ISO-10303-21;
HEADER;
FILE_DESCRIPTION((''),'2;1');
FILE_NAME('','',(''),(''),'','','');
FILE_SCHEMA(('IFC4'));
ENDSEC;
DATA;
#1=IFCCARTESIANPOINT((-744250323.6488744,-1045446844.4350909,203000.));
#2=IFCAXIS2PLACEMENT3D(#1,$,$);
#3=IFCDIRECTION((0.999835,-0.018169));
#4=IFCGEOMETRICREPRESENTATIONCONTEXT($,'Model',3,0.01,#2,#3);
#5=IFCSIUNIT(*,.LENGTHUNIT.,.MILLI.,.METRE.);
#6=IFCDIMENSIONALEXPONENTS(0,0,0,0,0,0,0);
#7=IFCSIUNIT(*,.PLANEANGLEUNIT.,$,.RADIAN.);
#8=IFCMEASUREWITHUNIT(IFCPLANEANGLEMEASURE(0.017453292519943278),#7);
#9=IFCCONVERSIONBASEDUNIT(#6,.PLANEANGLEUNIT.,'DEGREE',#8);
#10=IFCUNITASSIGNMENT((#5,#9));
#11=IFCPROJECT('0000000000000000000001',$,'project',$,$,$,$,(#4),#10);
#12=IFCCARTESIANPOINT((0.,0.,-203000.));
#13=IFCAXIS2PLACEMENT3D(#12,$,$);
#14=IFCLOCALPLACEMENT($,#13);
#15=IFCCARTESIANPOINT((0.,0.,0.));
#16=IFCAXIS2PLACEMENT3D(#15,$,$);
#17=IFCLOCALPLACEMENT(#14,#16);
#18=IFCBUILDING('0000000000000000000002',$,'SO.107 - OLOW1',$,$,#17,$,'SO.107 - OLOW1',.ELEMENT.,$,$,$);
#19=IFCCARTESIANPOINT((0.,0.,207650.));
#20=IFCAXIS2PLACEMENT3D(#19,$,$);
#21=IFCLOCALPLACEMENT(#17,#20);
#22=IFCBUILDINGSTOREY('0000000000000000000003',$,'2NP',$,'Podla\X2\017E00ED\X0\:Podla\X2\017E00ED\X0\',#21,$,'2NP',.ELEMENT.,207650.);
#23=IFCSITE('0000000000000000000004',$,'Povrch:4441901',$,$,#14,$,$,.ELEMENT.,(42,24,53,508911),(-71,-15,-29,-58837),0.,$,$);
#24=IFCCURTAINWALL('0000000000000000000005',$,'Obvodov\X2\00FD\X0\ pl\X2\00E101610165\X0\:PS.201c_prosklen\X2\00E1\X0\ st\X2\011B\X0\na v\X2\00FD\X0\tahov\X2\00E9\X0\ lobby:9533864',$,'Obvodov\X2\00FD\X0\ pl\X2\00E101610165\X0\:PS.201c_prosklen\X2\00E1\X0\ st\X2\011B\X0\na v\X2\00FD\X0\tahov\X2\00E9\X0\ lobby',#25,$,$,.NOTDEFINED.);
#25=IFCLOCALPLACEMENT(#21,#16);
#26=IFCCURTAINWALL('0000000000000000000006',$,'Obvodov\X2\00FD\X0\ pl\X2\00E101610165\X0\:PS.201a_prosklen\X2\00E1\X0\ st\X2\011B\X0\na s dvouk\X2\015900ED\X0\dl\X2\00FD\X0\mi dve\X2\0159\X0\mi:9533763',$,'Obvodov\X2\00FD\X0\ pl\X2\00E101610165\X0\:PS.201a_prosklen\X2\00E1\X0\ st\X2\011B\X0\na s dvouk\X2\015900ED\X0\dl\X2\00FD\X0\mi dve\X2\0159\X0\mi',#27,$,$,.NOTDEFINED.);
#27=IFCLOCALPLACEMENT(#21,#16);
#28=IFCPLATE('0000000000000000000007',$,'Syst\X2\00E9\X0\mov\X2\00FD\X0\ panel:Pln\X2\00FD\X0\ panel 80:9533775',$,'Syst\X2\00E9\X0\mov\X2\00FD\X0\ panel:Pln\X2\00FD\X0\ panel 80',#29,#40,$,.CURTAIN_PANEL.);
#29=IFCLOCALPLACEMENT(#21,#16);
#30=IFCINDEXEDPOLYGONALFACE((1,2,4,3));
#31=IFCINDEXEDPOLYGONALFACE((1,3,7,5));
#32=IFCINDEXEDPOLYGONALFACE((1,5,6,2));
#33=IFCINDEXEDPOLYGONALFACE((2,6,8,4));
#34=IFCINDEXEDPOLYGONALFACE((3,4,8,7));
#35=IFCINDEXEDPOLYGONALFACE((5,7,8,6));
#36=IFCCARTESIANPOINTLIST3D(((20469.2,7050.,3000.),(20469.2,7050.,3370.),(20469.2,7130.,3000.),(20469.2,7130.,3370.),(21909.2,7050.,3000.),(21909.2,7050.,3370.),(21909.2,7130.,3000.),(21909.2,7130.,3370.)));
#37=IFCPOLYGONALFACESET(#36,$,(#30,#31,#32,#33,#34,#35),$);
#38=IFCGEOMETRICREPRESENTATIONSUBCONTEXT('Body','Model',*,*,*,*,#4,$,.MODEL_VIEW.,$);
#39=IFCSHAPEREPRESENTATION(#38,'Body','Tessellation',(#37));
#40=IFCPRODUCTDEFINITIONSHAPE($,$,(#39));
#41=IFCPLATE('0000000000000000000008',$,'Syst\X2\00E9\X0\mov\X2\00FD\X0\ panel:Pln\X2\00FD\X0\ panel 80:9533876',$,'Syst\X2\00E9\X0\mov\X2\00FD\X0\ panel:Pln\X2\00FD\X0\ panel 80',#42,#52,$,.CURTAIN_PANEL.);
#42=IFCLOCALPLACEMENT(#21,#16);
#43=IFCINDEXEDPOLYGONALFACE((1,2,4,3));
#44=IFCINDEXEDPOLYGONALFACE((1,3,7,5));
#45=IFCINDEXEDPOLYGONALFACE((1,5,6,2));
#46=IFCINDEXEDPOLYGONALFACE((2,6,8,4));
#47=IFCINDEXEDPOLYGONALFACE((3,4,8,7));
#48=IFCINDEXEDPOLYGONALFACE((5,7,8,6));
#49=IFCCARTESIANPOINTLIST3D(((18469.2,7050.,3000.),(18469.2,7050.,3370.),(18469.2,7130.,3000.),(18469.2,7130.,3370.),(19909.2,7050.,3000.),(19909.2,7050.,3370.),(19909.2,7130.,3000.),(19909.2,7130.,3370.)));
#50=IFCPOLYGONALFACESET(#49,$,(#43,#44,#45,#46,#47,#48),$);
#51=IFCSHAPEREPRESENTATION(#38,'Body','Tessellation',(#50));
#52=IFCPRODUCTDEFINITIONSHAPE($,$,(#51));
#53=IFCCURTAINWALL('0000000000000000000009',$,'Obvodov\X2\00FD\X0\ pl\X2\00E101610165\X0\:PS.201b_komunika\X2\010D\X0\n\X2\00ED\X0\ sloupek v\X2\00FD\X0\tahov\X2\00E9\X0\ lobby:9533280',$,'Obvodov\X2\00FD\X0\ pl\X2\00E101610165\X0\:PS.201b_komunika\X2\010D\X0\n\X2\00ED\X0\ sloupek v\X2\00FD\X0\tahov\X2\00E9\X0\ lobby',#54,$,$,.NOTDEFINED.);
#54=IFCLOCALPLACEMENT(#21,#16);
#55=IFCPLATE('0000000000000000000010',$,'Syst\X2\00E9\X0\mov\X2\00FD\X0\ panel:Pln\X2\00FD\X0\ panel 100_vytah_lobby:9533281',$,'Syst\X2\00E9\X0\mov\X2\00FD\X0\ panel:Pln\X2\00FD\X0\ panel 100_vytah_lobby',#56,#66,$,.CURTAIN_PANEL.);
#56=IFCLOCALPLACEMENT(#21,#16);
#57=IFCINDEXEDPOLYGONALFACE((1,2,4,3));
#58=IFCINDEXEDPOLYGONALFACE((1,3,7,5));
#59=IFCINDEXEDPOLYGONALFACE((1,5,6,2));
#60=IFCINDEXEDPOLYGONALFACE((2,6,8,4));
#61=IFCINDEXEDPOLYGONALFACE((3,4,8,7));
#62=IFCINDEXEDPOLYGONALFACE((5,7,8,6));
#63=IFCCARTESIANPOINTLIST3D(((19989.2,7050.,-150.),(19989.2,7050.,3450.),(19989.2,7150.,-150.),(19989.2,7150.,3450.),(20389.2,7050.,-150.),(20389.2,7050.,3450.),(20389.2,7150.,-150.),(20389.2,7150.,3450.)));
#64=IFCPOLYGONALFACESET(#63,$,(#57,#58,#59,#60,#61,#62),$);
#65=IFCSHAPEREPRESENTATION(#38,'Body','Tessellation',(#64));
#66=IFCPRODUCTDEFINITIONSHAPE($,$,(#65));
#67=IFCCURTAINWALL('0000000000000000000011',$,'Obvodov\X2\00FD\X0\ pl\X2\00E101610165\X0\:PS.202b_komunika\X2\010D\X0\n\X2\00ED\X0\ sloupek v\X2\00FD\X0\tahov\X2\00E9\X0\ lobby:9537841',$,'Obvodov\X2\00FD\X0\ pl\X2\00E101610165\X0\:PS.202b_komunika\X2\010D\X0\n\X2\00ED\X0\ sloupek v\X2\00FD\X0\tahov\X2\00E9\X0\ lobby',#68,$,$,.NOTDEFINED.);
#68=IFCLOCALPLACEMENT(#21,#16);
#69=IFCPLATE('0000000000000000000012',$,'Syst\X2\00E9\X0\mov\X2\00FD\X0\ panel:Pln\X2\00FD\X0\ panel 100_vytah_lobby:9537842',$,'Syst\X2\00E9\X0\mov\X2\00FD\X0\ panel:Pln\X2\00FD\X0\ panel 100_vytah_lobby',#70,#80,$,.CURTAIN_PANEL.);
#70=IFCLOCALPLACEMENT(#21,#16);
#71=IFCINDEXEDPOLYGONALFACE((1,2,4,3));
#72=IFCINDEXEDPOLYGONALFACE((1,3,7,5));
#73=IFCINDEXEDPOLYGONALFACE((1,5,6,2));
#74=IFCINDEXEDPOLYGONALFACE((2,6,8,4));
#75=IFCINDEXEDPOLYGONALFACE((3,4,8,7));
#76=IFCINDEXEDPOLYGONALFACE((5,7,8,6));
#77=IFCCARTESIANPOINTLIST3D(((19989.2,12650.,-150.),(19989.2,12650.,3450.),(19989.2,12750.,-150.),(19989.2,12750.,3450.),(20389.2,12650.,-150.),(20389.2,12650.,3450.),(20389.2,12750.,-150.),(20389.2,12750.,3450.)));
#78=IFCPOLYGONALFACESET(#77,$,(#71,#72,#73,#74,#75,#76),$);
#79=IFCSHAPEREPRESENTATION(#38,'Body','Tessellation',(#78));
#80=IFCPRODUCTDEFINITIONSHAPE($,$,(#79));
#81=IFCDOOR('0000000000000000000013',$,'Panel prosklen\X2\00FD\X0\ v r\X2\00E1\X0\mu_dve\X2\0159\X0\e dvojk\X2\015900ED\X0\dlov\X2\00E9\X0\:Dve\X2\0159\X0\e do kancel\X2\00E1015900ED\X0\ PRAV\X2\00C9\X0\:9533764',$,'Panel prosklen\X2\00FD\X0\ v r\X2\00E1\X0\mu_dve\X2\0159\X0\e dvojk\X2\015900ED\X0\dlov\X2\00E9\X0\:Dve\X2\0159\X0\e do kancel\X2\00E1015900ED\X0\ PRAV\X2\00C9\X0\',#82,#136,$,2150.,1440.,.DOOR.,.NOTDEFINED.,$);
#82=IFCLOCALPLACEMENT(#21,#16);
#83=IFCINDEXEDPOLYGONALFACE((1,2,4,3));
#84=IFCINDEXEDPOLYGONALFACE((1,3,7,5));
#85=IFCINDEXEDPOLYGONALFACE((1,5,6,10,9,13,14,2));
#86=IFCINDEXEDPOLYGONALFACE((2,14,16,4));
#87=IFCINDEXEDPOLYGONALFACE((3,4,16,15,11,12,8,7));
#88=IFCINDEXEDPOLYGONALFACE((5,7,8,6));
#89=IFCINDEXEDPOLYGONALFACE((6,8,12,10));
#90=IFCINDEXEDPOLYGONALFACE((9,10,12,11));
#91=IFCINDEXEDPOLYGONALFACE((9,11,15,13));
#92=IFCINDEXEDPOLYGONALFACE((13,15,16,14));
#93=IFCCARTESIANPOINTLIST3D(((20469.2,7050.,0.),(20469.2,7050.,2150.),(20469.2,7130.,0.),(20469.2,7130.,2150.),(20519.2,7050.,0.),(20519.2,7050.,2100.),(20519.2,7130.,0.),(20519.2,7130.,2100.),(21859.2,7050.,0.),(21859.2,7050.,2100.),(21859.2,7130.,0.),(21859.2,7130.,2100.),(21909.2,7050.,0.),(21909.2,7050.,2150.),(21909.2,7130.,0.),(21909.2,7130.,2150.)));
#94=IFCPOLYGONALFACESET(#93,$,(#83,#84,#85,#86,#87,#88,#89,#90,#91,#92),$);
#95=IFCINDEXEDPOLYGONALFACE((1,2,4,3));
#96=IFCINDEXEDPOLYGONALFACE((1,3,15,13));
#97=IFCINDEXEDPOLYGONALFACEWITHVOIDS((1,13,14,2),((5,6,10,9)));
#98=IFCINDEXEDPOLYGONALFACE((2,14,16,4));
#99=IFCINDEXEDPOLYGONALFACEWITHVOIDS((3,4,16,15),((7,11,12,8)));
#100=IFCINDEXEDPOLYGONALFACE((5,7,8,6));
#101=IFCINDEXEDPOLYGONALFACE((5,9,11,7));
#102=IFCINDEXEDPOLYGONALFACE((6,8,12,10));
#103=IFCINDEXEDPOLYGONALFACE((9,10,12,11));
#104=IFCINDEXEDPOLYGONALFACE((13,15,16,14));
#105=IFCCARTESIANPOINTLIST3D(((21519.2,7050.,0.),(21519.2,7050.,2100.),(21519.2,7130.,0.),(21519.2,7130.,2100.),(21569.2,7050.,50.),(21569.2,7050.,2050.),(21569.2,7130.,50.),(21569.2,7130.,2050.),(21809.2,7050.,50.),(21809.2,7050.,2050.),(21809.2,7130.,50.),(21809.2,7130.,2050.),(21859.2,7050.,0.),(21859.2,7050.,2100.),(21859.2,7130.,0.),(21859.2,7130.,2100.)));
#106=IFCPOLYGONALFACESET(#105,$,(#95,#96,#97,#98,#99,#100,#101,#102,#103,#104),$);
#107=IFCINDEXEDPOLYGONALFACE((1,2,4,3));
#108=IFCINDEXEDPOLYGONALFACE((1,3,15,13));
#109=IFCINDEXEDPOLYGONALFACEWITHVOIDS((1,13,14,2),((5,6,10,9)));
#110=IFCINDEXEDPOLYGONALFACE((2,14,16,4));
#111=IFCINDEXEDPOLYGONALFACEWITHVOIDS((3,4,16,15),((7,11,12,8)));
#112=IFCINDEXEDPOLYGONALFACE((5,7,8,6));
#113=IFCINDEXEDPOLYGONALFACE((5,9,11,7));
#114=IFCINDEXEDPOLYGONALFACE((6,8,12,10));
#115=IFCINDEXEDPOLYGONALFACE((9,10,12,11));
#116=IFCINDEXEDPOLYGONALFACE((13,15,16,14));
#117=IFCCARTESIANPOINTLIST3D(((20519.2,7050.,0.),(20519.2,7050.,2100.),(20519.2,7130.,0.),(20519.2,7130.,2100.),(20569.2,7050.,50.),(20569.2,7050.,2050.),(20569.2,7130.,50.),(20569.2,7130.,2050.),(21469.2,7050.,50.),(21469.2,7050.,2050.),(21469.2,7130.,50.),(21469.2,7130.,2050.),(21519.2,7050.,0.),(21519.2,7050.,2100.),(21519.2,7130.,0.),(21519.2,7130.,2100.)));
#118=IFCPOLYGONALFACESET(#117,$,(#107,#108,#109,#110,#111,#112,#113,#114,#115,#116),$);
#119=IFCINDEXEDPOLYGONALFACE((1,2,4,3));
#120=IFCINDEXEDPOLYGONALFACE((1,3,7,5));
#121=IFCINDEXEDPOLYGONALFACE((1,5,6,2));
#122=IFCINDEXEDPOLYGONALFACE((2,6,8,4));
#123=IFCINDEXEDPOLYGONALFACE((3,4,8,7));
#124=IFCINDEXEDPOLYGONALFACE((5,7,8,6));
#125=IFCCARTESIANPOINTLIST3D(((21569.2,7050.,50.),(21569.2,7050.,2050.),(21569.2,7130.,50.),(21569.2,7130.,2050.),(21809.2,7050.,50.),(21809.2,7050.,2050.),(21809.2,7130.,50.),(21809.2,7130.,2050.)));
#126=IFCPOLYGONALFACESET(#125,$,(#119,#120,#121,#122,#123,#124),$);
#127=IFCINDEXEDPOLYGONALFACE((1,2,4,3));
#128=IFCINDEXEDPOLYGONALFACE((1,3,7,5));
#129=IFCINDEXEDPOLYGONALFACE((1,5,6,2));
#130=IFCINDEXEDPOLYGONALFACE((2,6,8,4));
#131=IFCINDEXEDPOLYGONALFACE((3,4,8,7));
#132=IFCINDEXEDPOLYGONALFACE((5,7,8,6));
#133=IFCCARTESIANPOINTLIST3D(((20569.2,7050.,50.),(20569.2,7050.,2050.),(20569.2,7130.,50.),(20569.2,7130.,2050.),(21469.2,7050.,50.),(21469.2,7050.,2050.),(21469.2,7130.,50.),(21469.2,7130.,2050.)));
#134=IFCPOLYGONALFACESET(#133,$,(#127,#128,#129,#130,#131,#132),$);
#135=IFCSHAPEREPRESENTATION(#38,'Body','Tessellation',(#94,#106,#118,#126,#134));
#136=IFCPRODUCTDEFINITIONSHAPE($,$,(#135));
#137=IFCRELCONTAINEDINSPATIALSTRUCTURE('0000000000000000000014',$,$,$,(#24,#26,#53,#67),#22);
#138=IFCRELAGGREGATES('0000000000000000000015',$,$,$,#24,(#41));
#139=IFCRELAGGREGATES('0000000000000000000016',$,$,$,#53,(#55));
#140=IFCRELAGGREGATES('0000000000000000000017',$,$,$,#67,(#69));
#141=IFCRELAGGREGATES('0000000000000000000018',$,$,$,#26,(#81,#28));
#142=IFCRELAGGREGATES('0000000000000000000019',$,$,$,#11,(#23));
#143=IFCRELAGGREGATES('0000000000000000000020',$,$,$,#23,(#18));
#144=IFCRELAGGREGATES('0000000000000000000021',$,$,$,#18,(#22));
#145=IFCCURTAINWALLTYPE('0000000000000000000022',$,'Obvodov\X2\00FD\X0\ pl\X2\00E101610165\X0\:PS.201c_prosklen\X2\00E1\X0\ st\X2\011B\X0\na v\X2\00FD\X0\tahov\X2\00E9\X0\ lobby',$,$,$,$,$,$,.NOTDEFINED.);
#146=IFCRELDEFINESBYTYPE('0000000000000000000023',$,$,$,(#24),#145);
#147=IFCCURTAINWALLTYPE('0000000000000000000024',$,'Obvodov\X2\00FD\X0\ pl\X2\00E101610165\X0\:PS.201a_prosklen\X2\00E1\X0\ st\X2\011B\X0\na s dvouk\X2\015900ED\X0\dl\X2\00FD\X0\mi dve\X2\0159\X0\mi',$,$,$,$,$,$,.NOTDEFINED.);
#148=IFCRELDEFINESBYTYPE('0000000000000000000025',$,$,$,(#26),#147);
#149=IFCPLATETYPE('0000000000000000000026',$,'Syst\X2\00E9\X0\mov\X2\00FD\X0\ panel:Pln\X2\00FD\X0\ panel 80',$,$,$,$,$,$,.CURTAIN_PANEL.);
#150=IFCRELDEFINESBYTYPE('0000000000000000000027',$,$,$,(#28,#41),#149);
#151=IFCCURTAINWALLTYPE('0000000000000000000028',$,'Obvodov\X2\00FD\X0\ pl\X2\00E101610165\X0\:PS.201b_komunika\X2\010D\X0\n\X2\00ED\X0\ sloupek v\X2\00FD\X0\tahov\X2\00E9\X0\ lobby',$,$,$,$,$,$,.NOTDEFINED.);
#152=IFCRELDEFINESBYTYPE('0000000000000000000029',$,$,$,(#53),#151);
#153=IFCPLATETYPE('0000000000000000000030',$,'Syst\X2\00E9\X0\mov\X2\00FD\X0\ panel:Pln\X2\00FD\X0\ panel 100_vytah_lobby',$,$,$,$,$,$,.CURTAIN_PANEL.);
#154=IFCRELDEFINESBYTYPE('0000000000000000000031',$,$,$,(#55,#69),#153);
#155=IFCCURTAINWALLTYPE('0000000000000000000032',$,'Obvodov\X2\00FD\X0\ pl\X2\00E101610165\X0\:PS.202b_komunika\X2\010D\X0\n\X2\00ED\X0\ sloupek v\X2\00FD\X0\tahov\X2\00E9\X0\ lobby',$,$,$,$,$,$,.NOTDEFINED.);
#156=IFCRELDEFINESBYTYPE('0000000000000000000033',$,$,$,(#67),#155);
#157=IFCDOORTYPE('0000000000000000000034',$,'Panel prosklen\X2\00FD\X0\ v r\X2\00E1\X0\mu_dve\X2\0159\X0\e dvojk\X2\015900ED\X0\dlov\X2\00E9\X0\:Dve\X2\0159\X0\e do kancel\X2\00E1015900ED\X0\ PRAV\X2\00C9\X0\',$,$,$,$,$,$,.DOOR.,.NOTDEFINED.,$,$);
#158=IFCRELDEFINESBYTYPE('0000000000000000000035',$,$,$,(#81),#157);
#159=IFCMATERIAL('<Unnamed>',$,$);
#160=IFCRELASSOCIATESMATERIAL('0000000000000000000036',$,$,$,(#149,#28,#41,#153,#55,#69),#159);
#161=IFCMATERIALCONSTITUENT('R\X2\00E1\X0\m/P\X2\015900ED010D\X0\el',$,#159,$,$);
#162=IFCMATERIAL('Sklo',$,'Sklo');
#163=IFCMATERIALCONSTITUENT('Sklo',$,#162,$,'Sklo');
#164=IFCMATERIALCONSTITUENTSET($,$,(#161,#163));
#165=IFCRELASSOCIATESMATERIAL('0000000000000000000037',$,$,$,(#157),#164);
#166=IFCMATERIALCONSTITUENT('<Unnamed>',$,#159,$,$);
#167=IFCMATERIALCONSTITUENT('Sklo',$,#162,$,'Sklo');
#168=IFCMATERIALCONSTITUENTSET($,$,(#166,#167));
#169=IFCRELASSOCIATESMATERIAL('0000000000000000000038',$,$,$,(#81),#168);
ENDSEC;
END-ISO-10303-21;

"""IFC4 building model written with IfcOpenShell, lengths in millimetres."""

from ifc_helpers import new_model, entity, si_unit, converted_unit, direction, frame, origin, place, context, subcontext, project, spatial, indexed_curve, outline, extrude, source, transform, mapped, material, constituent, constituent_set, type_object, type_shapes, element, aggregate, save


model = new_model("IFC4")

# Units and contexts
model_context = context("Model", 3, precision=0.01, world=frame((-744250323.6488744, -1045446844.4350909, 203000.0)), true_north=direction((0.999835, -0.018169)))
body_context = subcontext(model_context, "Body", "Model", "MODEL_VIEW")
ifc_project = project(units=[si_unit("LENGTHUNIT", "METRE", prefix="MILLI"), converted_unit("PLANEANGLEUNIT", "DEGREE", entity("IfcPlaneAngleMeasure", 0.017453292519943278), si_unit("PLANEANGLEUNIT", "RADIAN"), dimensions=[0, 0, 0, 0, 0, 0, 0])], contexts=[model_context])

# Site, building, storey
site_placement = place(None, frame((0.0, 0.0, -203000.0)))
site = spatial("IfcSite", under=ifc_project, at=site_placement, Name="Povrch:4441901", CompositionType="ELEMENT", RefLatitude=(42, 24, 53, 508911), RefLongitude=(-71, -15, -29, -58837), RefElevation=0.0)
building_placement = place(site_placement, origin())
building = spatial("IfcBuilding", under=site, at=building_placement, Name="SO.107 - OLOW1", LongName="SO.107 - OLOW1", CompositionType="ELEMENT")
storey_placement = place(building_placement, frame((0.0, 0.0, 207650.0)))
storey = spatial("IfcBuildingStorey", under=building, at=storey_placement, Name="2NP", ObjectType="Podlaží:Podlaží", LongName="2NP", CompositionType="ELEMENT", Elevation=207650.0)

# Curtain walls
ifc_material_1 = material(Name="<Unnamed>")
curtain_wall_type_1 = type_object("IfcCurtainWallType", Name="Obvodový plášť:PS.201c_prosklená stěna výtahové lobby", PredefinedType="NOTDEFINED")
curtain_wall_1_placement = place(storey_placement, frame((0.0, 0.0, -207650.0)))
curtain_wall_1 = element("IfcCurtainWall", 1, at=curtain_wall_1_placement, inside=storey, type_object=curtain_wall_type_1, Name="Obvodový plášť:PS.201c_prosklená stěna výtahové lobby:9533864", ObjectType="Obvodový plášť:PS.201c_prosklená stěna výtahové lobby", PredefinedType="NOTDEFINED")
curtain_wall_type_2 = type_object("IfcCurtainWallType", Name="Obvodový plášť:PS.201a_prosklená stěna s dvoukřídlými dveřmi", PredefinedType="NOTDEFINED")
curtain_wall_2_placement = place(storey_placement, frame((0.0, 0.0, -207650.0)))
curtain_wall_2 = element("IfcCurtainWall", 2, at=curtain_wall_2_placement, inside=storey, type_object=curtain_wall_type_2, Name="Obvodový plášť:PS.201a_prosklená stěna s dvoukřídlými dveřmi:9533763", ObjectType="Obvodový plášť:PS.201a_prosklená stěna s dvoukřídlými dveřmi", PredefinedType="NOTDEFINED")

# Plates
ifc_material_2 = material(Name="Sklo", Category="Sklo")
plate_type_1 = type_object("IfcPlateType", Name="Systémový panel:Plný panel 80", PredefinedType="CURTAIN_PANEL", material=ifc_material_1)
shared_shape_1 = source(origin(), body_context, "Body", "SweptSolid", [
    extrude(outline(indexed_curve([(-40.0, -720.0), (40.0, -720.0), (40.0, 720.0), (-40.0, 720.0), (-40.0, -720.0)], self_intersect=False)), frame((0.0, 0.0, 0.0), z_axis=(0.0, 0.0, 1.0), x_axis=(0.0, 1.0, 0.0)), (0.0, 0.0, 1.0), 370.0),
])
type_shapes(plate_type_1, [shared_shape_1])
plate_1_placement = place(curtain_wall_2_placement, frame((21189.2, 7090.0, 210650.0)))
plate_1 = element("IfcPlate", 3, at=plate_1_placement, type_object=plate_type_1, material=ifc_material_1, Name="Systémový panel:Plný panel 80:9533775", ObjectType="Systémový panel:Plný panel 80", PredefinedType="CURTAIN_PANEL", context=body_context, shape_type="MappedRepresentation", body=[
    mapped(shared_shape_1, transform((0.0, 0.0, 0.0), scale=1.0)),
])
plate_2_placement = place(curtain_wall_1_placement, frame((19189.2, 7090.0, 210650.0)))
plate_2 = element("IfcPlate", 4, at=plate_2_placement, type_object=plate_type_1, material=ifc_material_1, Name="Systémový panel:Plný panel 80:9533876", ObjectType="Systémový panel:Plný panel 80", PredefinedType="CURTAIN_PANEL", context=body_context, shape_type="MappedRepresentation", body=[
    mapped(shared_shape_1, transform((0.0, 0.0, 0.0), scale=1.0)),
])
aggregate(curtain_wall_1, [plate_2])

# Curtain walls, plates
curtain_wall_type_3 = type_object("IfcCurtainWallType", Name="Obvodový plášť:PS.201b_komunikační sloupek výtahové lobby", PredefinedType="NOTDEFINED")
curtain_wall_3_placement = place(storey_placement, frame((0.0, 0.0, -207650.0)))
curtain_wall_3 = element("IfcCurtainWall", 5, at=curtain_wall_3_placement, inside=storey, type_object=curtain_wall_type_3, Name="Obvodový plášť:PS.201b_komunikační sloupek výtahové lobby:9533280", ObjectType="Obvodový plášť:PS.201b_komunikační sloupek výtahové lobby", PredefinedType="NOTDEFINED")
plate_type_2 = type_object("IfcPlateType", Name="Systémový panel:Plný panel 100_vytah_lobby", PredefinedType="CURTAIN_PANEL", material=ifc_material_1)
shared_shape_2 = source(origin(), body_context, "Body", "SweptSolid", [
    extrude(outline(indexed_curve([(-50.0, -200.0), (50.0, -200.0), (50.0, 200.0), (-50.0, 200.0), (-50.0, -200.0)], self_intersect=False)), frame((0.0, 10.0, 0.0), z_axis=(0.0, 0.0, 1.0), x_axis=(0.0, 1.0, 0.0)), (0.0, 0.0, 1.0), 3600.0),
])
type_shapes(plate_type_2, [shared_shape_2])
plate_3_placement = place(curtain_wall_3_placement, frame((20189.2, 7090.0, 207500.0)))
plate_3 = element("IfcPlate", 6, at=plate_3_placement, type_object=plate_type_2, material=ifc_material_1, Name="Systémový panel:Plný panel 100_vytah_lobby:9533281", ObjectType="Systémový panel:Plný panel 100_vytah_lobby", PredefinedType="CURTAIN_PANEL", context=body_context, shape_type="MappedRepresentation", body=[
    mapped(shared_shape_2, transform((0.0, 0.0, 0.0), scale=1.0)),
])
aggregate(curtain_wall_3, [plate_3])
curtain_wall_type_4 = type_object("IfcCurtainWallType", Name="Obvodový plášť:PS.202b_komunikační sloupek výtahové lobby", PredefinedType="NOTDEFINED")
curtain_wall_4_placement = place(storey_placement, frame((0.0, 0.0, -207650.0)))
curtain_wall_4 = element("IfcCurtainWall", 7, at=curtain_wall_4_placement, inside=storey, type_object=curtain_wall_type_4, Name="Obvodový plášť:PS.202b_komunikační sloupek výtahové lobby:9537841", ObjectType="Obvodový plášť:PS.202b_komunikační sloupek výtahové lobby", PredefinedType="NOTDEFINED")
plate_4_placement = place(curtain_wall_4_placement, frame((20189.2, 12690.0, 207500.0)))
plate_4 = element("IfcPlate", 8, at=plate_4_placement, type_object=plate_type_2, material=ifc_material_1, Name="Systémový panel:Plný panel 100_vytah_lobby:9537842", ObjectType="Systémový panel:Plný panel 100_vytah_lobby", PredefinedType="CURTAIN_PANEL", context=body_context, shape_type="MappedRepresentation", body=[
    mapped(shared_shape_2, transform((0.0, 0.0, 0.0), scale=1.0)),
])
aggregate(curtain_wall_4, [plate_4])

# Door
ifc_constituent_1 = constituent(ifc_material_1, Name="<Unnamed>")
ifc_constituent_2 = constituent(ifc_material_2, Name="Sklo", Category="Sklo")
ifc_constituent_set_1 = constituent_set(constituents=[ifc_constituent_1, ifc_constituent_2])
ifc_constituent_3 = constituent(ifc_material_1, Name="Rám/Příčel")
ifc_constituent_4 = constituent(ifc_material_2, Name="Sklo", Category="Sklo")
ifc_constituent_set_2 = constituent_set(constituents=[ifc_constituent_3, ifc_constituent_4])
door_type = type_object("IfcDoorType", Name="Panel prosklený v rámu_dveře dvojkřídlové:Dveře do kanceláří PRAVÉ", OperationType="NOTDEFINED", PredefinedType="DOOR", material=ifc_constituent_set_2)
shared_shape_3 = source(origin(), body_context, "Body", "SweptSolid", [
    extrude(outline(indexed_curve([(-720.0, -1087.5), (720.0, -1087.5), (720.0, 1062.5), (670.0, 1062.5), (670.0, -1037.5), (-670.0, -1037.5), (-670.0, 1062.5), (-720.0, 1062.5), (-720.0, -1087.5)], self_intersect=False)), frame((0.0, 40.0, 1062.5), z_axis=(0.0, -1.0, 0.0), x_axis=(-1.0, 0.0, 0.0)), (0.0, 0.0, 1.0), 80.0),
    extrude(outline(indexed_curve([(-1050.0, -170.0), (1050.0, -170.0), (1050.0, 170.0), (-1050.0, 170.0), (-1050.0, -170.0)], self_intersect=False), holes=[indexed_curve([(-1000.0, -120.0), (-1000.0, 120.0), (1000.0, 120.0), (1000.0, -120.0), (-1000.0, -120.0)], self_intersect=False)]), frame((-500.0, 40.0, 1050.0), z_axis=(0.0, -1.0, 0.0), x_axis=(0.0, 0.0, -1.0)), (0.0, 0.0, 1.0), 80.0),
    extrude(outline(indexed_curve([(-1050.0, -500.0), (1050.0, -500.0), (1050.0, 500.0), (-1050.0, 500.0), (-1050.0, -500.0)], self_intersect=False), holes=[indexed_curve([(-1000.0, -450.0), (-1000.0, 450.0), (1000.0, 450.0), (1000.0, -450.0), (-1000.0, -450.0)], self_intersect=False)]), frame((170.0, 40.0, 1050.0), z_axis=(0.0, -1.0, 0.0), x_axis=(0.0, 0.0, -1.0)), (0.0, 0.0, 1.0), 80.0),
    extrude(outline(indexed_curve([(-120.0, -40.0), (120.0, -40.0), (120.0, 40.0), (-120.0, 40.0), (-120.0, -40.0)], self_intersect=False)), frame((-500.0, 0.0, 50.0)), (0.0, 0.0, 1.0), 2000.0),
    extrude(outline(indexed_curve([(-450.0, -40.0), (450.0, -40.0), (450.0, 40.0), (-450.0, 40.0), (-450.0, -40.0)], self_intersect=False)), frame((170.0, 0.0, 50.0)), (0.0, 0.0, 1.0), 2000.0),
])
type_shapes(door_type, [shared_shape_3])
door_placement = place(curtain_wall_2_placement, frame((21189.2, 7090.0, 207650.0), z_axis=(0.0, 0.0, 1.0), x_axis=(-1.0, 0.0, 0.0)))
door = element("IfcDoor", 9, at=door_placement, type_object=door_type, material=ifc_constituent_set_1, Name="Panel prosklený v rámu_dveře dvojkřídlové:Dveře do kanceláří PRAVÉ:9533764", ObjectType="Panel prosklený v rámu_dveře dvojkřídlové:Dveře do kanceláří PRAVÉ", OperationType="NOTDEFINED", OverallHeight=2150.0, OverallWidth=1440.0, PredefinedType="DOOR", context=body_context, shape_type="MappedRepresentation", body=[
    mapped(shared_shape_3, transform((0.0, 0.0, 0.0), scale=1.0)),
])
aggregate(curtain_wall_2, [door, plate_1])

save(model, "model.ifc")
